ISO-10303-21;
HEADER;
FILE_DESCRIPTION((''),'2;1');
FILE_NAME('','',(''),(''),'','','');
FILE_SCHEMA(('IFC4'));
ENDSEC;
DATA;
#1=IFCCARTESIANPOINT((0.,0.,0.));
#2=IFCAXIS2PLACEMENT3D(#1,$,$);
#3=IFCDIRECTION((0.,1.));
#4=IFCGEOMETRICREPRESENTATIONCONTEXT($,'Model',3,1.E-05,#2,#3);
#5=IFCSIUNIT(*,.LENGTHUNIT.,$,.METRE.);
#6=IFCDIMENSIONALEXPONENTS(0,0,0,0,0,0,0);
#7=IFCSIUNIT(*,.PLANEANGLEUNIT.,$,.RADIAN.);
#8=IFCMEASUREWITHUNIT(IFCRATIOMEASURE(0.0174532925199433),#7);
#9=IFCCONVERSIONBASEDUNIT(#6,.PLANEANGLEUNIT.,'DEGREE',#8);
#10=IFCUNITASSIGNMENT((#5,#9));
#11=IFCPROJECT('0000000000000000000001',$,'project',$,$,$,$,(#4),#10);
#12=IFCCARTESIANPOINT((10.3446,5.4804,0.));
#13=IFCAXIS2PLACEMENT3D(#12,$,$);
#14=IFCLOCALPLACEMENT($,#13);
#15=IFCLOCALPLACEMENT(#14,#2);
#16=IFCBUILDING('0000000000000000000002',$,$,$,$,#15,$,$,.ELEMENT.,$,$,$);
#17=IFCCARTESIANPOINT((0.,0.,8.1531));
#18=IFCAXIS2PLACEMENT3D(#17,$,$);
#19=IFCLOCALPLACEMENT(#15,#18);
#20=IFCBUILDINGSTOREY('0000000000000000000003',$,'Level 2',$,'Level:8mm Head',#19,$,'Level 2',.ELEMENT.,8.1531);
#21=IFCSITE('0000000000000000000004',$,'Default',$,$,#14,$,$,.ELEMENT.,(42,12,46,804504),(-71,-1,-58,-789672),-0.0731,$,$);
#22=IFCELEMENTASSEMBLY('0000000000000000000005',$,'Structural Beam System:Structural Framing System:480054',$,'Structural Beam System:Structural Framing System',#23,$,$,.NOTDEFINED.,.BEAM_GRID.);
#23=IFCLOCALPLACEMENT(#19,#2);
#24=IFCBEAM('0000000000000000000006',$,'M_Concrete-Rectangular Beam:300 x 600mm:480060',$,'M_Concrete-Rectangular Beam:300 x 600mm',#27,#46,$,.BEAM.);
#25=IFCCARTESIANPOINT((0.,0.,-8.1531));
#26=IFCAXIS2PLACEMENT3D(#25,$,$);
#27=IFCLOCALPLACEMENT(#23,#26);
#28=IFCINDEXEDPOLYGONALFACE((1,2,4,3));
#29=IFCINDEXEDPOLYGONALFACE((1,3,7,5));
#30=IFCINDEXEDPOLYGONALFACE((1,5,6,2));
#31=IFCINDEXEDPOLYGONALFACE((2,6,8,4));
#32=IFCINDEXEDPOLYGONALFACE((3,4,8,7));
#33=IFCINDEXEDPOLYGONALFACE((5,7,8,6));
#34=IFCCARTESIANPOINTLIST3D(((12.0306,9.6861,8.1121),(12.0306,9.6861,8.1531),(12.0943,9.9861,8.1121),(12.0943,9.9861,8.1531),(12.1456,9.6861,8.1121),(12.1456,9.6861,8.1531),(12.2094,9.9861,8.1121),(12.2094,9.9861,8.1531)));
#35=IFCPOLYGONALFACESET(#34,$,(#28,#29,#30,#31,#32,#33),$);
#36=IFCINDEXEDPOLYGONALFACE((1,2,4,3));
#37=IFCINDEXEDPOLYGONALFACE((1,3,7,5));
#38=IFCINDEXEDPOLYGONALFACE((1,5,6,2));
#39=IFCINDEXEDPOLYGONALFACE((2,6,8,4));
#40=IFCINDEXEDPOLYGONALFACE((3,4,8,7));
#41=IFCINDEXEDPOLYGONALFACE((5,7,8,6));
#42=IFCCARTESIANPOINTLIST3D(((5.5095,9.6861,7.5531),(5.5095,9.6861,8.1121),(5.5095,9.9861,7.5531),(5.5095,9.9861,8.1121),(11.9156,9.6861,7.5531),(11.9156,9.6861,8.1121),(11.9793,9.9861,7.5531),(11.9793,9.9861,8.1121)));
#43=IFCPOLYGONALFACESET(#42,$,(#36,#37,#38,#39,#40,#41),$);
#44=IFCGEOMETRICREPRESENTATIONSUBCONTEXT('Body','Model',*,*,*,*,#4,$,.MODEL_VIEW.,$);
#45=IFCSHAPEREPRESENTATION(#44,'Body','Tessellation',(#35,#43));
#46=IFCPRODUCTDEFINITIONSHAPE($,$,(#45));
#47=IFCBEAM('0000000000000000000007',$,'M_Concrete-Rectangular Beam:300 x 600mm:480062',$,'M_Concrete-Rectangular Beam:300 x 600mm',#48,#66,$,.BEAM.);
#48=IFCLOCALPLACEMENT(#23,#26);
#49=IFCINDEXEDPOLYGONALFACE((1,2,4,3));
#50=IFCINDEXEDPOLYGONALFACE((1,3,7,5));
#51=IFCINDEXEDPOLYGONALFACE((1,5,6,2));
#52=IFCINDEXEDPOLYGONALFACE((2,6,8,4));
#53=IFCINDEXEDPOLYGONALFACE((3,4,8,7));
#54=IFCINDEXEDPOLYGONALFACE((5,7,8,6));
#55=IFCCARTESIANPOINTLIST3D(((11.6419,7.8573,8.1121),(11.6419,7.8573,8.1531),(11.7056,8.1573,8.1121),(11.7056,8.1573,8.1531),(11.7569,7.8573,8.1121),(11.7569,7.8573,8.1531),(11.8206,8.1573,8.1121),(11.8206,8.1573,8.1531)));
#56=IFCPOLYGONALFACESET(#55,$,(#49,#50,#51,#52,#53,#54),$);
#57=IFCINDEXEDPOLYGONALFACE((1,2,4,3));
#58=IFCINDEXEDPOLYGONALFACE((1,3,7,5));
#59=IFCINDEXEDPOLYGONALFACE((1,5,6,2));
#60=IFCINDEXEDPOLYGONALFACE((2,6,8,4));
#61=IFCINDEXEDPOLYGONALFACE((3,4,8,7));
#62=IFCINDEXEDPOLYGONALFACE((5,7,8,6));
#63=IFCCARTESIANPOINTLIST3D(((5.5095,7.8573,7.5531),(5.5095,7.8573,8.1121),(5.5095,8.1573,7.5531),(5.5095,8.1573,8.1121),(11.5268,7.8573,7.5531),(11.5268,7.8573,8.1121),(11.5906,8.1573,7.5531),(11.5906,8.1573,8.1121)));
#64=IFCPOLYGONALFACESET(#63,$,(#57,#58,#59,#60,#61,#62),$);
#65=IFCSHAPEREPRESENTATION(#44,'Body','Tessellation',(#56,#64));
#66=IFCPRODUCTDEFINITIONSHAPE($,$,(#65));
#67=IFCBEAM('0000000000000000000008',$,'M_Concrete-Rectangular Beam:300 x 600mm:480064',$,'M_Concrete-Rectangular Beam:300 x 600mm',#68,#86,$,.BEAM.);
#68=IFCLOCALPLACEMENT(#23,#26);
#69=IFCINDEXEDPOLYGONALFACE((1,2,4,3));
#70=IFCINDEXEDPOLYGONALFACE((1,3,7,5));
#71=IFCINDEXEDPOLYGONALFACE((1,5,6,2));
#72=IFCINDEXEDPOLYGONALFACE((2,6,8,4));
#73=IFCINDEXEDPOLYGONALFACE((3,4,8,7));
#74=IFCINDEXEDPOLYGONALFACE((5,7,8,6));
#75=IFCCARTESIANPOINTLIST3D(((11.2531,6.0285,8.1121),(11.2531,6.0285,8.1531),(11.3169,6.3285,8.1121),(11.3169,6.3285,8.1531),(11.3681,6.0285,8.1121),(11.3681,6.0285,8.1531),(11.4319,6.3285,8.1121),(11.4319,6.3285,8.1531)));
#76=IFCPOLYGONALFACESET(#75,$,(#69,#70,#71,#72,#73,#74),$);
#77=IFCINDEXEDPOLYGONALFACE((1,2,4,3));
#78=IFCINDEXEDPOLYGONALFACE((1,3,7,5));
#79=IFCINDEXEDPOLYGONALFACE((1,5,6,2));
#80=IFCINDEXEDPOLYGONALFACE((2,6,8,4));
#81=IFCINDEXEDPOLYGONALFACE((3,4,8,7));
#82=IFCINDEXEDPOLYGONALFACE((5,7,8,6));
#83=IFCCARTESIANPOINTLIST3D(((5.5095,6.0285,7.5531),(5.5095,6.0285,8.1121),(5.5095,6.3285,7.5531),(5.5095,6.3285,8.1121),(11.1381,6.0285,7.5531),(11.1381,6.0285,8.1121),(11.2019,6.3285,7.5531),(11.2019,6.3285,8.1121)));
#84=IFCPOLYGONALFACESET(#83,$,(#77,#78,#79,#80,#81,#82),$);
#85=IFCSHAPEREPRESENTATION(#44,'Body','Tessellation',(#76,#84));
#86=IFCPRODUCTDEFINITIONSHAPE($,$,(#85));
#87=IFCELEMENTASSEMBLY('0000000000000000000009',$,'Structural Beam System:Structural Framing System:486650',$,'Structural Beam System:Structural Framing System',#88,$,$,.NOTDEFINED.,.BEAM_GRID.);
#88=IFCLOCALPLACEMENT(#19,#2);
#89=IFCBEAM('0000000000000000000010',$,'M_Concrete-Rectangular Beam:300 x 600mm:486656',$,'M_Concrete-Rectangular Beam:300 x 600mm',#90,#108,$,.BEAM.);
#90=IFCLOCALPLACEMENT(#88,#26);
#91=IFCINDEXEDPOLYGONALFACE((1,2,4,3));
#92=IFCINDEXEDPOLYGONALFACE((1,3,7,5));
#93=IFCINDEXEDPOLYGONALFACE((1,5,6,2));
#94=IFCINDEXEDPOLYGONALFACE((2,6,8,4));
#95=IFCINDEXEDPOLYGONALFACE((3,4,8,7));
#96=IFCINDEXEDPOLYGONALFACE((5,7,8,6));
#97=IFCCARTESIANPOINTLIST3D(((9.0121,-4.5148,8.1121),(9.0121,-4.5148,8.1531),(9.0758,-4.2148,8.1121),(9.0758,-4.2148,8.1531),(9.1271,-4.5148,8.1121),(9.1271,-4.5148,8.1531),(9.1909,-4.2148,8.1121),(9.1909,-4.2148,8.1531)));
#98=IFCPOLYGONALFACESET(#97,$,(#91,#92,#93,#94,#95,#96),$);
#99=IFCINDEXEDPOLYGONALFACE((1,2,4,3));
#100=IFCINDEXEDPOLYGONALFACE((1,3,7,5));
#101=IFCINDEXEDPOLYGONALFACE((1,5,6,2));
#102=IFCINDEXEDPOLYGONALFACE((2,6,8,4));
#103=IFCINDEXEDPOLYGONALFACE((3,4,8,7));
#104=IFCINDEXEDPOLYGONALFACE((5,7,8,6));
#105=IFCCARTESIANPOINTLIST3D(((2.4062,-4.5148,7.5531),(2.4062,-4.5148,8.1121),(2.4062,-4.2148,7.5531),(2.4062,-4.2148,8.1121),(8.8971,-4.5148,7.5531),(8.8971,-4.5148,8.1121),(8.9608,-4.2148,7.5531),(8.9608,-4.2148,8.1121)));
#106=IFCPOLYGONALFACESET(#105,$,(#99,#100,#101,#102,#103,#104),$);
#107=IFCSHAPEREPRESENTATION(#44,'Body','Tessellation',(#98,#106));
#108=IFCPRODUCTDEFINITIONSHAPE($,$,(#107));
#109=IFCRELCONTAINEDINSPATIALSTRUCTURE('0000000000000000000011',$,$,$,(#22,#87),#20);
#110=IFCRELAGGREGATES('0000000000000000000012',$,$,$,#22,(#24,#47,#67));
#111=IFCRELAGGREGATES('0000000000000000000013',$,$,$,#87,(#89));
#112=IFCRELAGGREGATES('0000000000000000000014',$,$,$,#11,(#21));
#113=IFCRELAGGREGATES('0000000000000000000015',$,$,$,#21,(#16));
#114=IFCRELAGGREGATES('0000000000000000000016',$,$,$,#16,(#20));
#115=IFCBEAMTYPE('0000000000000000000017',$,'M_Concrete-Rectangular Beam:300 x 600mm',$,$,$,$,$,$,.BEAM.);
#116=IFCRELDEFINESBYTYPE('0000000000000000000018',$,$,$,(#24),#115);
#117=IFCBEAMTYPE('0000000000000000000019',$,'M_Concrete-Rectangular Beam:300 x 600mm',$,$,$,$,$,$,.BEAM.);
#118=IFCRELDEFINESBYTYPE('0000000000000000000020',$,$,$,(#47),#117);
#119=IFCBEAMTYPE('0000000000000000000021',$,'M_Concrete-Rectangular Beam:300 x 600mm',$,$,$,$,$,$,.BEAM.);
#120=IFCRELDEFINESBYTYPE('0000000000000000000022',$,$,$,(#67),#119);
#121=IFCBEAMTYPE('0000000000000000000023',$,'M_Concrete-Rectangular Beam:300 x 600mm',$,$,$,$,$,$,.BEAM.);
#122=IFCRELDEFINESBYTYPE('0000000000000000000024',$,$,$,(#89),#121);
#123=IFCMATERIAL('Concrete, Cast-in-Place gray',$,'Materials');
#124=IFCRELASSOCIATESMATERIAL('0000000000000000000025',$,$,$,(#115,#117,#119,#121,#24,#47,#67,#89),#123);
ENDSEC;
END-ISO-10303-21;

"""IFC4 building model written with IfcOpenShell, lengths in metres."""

from ifc_helpers import new_model, entity, si_unit, converted_unit, direction, frame, frame_2d, origin, place, context, subcontext, project, spatial, rectangle, extrude, clip, halfspace, source, transform, mapped, material, material_profile, profile_set, profile_usage, type_object, type_shapes, element, aggregate, save


model = new_model("IFC4")

# Units and contexts
model_context = context("Model", 3, precision=1e-05, world=origin(), true_north=direction((0.0, 1.0)))
body_context = subcontext(model_context, "Body", "Model", "MODEL_VIEW")
ifc_project = project(units=[si_unit("LENGTHUNIT", "METRE"), converted_unit("PLANEANGLEUNIT", "DEGREE", entity("IfcRatioMeasure", 0.0174532925199433), si_unit("PLANEANGLEUNIT", "RADIAN"), dimensions=[0, 0, 0, 0, 0, 0, 0])], contexts=[model_context])

# Site, building, storey
site_placement = place(None, frame((10.3446, 5.4804, 0.0)))
site = spatial("IfcSite", under=ifc_project, at=site_placement, Name="Default", CompositionType="ELEMENT", RefLatitude=(42, 12, 46, 804504), RefLongitude=(-71, -1, -58, -789672), RefElevation=-0.0731)
building_placement = place(site_placement, origin())
building = spatial("IfcBuilding", under=site, at=building_placement, CompositionType="ELEMENT")
storey_placement = place(building_placement, frame((0.0, 0.0, 8.1531)))
storey = spatial("IfcBuildingStorey", under=building, at=storey_placement, Name="Level 2", ObjectType="Level:8mm Head", LongName="Level 2", CompositionType="ELEMENT", Elevation=8.1531)

# Element assembly, beams
ifc_material_1 = material(Name="Concrete, Cast-in-Place gray", Category="Materials")
ifc_material_profile = material_profile(ifc_material_1, rectangle(XDim=0.559, YDim=0.3, at=frame_2d((0.0, 0.0), x_axis=(1.0, 0.0))), Name="300 x 600mm")
ifc_profile_set = profile_set([ifc_material_profile], Name="300 x 600mm")
assembly_1_placement = place(storey_placement, origin())
assembly_1 = element("IfcElementAssembly", 1, at=assembly_1_placement, inside=storey, Name="Structural Beam System:Structural Framing System:480054", ObjectType="Structural Beam System:Structural Framing System", AssemblyPlace="NOTDEFINED", PredefinedType="BEAM_GRID")
ifc_profile_usage_1 = profile_usage(ifc_profile_set, cardinal=8)
beam_type_1 = type_object("IfcBeamType", Name="M_Concrete-Rectangular Beam:300 x 600mm", PredefinedType="BEAM", material=ifc_profile_set)
shared_shape_1 = source(origin(), body_context, "Body", "Clipping", [
    clip(clip(extrude(rectangle(XDim=0.041, YDim=0.3, at=frame_2d((0.0, 0.0), x_axis=(1.0, 0.0))), frame((12.0306, 9.8361, 8.1326), z_axis=(1.0, 0.0, 0.0), x_axis=(0.0, 0.0, -1.0)), (0.0, 0.0, 1.0), 0.1788), halfspace(frame((12.1762, 10.3713, 8.1121), z_axis=(-0.978148, 0.207912, 0.0), x_axis=(0.0, 0.0, 1.0)), False)), halfspace(frame((12.1339, 9.6313, 8.5239), z_axis=(0.978148, -0.207912, 0.0), x_axis=(0.207912, 0.978148, 0.0)), False)),
    clip(extrude(rectangle(XDim=0.559, YDim=0.3, at=frame_2d((0.0, 0.0), x_axis=(1.0, 0.0))), frame((5.5095, 9.8361, 7.8326), z_axis=(1.0, 0.0, 0.0), x_axis=(0.0, 0.0, -1.0)), (0.0, 0.0, 1.0), 6.4698), halfspace(frame((8.6968, -5.457, 4.5531), z_axis=(0.978148, -0.207912, 0.0), x_axis=(-0.207912, -0.978148, 0.0)), False)),
])
type_shapes(beam_type_1, [shared_shape_1])
beam_1_placement = place(assembly_1_placement, frame((0.0, 0.0, -8.1531)))
beam_1 = element("IfcBeam", 2, at=beam_1_placement, type_object=beam_type_1, material=ifc_profile_usage_1, Name="M_Concrete-Rectangular Beam:300 x 600mm:480060", ObjectType="M_Concrete-Rectangular Beam:300 x 600mm", PredefinedType="BEAM", context=body_context, shape_type="MappedRepresentation", body=[
    mapped(shared_shape_1, transform((0.0, 0.0, 0.0), scale=1.0)),
])
ifc_profile_usage_2 = profile_usage(ifc_profile_set, cardinal=8)
beam_type_2 = type_object("IfcBeamType", Name="M_Concrete-Rectangular Beam:300 x 600mm", PredefinedType="BEAM", material=ifc_profile_set)
shared_shape_2 = source(origin(), body_context, "Body", "Clipping", [
    clip(clip(extrude(rectangle(XDim=0.041, YDim=0.3, at=frame_2d((0.0, 0.0), x_axis=(1.0, 0.0))), frame((11.6419, 8.0073, 8.1326), z_axis=(1.0, 0.0, 0.0), x_axis=(0.0, 0.0, -1.0)), (0.0, 0.0, 1.0), 0.1788), halfspace(frame((12.1762, 10.3713, 8.1121), z_axis=(-0.978148, 0.207912, 0.0), x_axis=(0.0, 0.0, 1.0)), False)), halfspace(frame((11.7452, 7.8025, 8.5239), z_axis=(0.978148, -0.207912, 0.0), x_axis=(0.207912, 0.978148, 0.0)), False)),
    clip(extrude(rectangle(XDim=0.559, YDim=0.3, at=frame_2d((0.0, 0.0), x_axis=(1.0, 0.0))), frame((5.5095, 8.0073, 7.8326), z_axis=(1.0, 0.0, 0.0), x_axis=(0.0, 0.0, -1.0)), (0.0, 0.0, 1.0), 6.0811), halfspace(frame((8.6968, -5.457, 4.5531), z_axis=(0.978148, -0.207912, 0.0), x_axis=(-0.207912, -0.978148, 0.0)), False)),
])
type_shapes(beam_type_2, [shared_shape_2])
beam_2_placement = place(assembly_1_placement, frame((0.0, 0.0, -8.1531)))
beam_2 = element("IfcBeam", 3, at=beam_2_placement, type_object=beam_type_2, material=ifc_profile_usage_2, Name="M_Concrete-Rectangular Beam:300 x 600mm:480062", ObjectType="M_Concrete-Rectangular Beam:300 x 600mm", PredefinedType="BEAM", context=body_context, shape_type="MappedRepresentation", body=[
    mapped(shared_shape_2, transform((0.0, 0.0, 0.0), scale=1.0)),
])
ifc_profile_usage_3 = profile_usage(ifc_profile_set, cardinal=8)
beam_type_3 = type_object("IfcBeamType", Name="M_Concrete-Rectangular Beam:300 x 600mm", PredefinedType="BEAM", material=ifc_profile_set)
shared_shape_3 = source(origin(), body_context, "Body", "Clipping", [
    clip(clip(extrude(rectangle(XDim=0.041, YDim=0.3, at=frame_2d((0.0, 0.0), x_axis=(1.0, 0.0))), frame((11.2531, 6.1785, 8.1326), z_axis=(1.0, 0.0, 0.0), x_axis=(0.0, 0.0, -1.0)), (0.0, 0.0, 1.0), 0.1788), halfspace(frame((12.1762, 10.3713, 8.1121), z_axis=(-0.978148, 0.207912, 0.0), x_axis=(0.0, 0.0, 1.0)), False)), halfspace(frame((11.3565, 5.9737, 8.5239), z_axis=(0.978148, -0.207912, 0.0), x_axis=(0.207912, 0.978148, 0.0)), False)),
    clip(extrude(rectangle(XDim=0.559, YDim=0.3, at=frame_2d((0.0, 0.0), x_axis=(1.0, 0.0))), frame((5.5095, 6.1785, 7.8326), z_axis=(1.0, 0.0, 0.0), x_axis=(0.0, 0.0, -1.0)), (0.0, 0.0, 1.0), 5.6923), halfspace(frame((8.6968, -5.457, 4.5531), z_axis=(0.978148, -0.207912, 0.0), x_axis=(-0.207912, -0.978148, 0.0)), False)),
])
type_shapes(beam_type_3, [shared_shape_3])
beam_3_placement = place(assembly_1_placement, frame((0.0, 0.0, -8.1531)))
beam_3 = element("IfcBeam", 4, at=beam_3_placement, type_object=beam_type_3, material=ifc_profile_usage_3, Name="M_Concrete-Rectangular Beam:300 x 600mm:480064", ObjectType="M_Concrete-Rectangular Beam:300 x 600mm", PredefinedType="BEAM", context=body_context, shape_type="MappedRepresentation", body=[
    mapped(shared_shape_3, transform((0.0, 0.0, 0.0), scale=1.0)),
])
aggregate(assembly_1, [beam_1, beam_2, beam_3])

# Element assembly, beam
assembly_2_placement = place(storey_placement, origin())
assembly_2 = element("IfcElementAssembly", 5, at=assembly_2_placement, inside=storey, Name="Structural Beam System:Structural Framing System:486650", ObjectType="Structural Beam System:Structural Framing System", AssemblyPlace="NOTDEFINED", PredefinedType="BEAM_GRID")
ifc_profile_usage_4 = profile_usage(ifc_profile_set, cardinal=8)
beam_type_4 = type_object("IfcBeamType", Name="M_Concrete-Rectangular Beam:300 x 600mm", PredefinedType="BEAM", material=ifc_profile_set)
shared_shape_4 = source(origin(), body_context, "Body", "Clipping", [
    clip(clip(extrude(rectangle(XDim=0.041, YDim=0.3, at=frame_2d((0.0, 0.0), x_axis=(1.0, 0.0))), frame((9.0121, -4.3648, 8.1326), z_axis=(1.0, 0.0, 0.0), x_axis=(0.0, 0.0, -1.0)), (0.0, 0.0, 1.0), 0.1788), halfspace(frame((10.4473, 2.2371, 8.1121), z_axis=(-0.978148, 0.207912, 0.0), x_axis=(0.0, 0.0, 1.0)), False)), halfspace(frame((9.1154, -4.5697, 8.5239), z_axis=(0.978148, -0.207912, 0.0), x_axis=(0.207912, 0.978148, 0.0)), False)),
    clip(extrude(rectangle(XDim=0.559, YDim=0.3, at=frame_2d((0.0, 0.0), x_axis=(1.0, 0.0))), frame((2.4062, -4.3648, 7.8326), z_axis=(1.0, 0.0, 0.0), x_axis=(0.0, 0.0, -1.0)), (0.0, 0.0, 1.0), 6.5547), halfspace(frame((8.6968, -5.457, 4.5531), z_axis=(0.978148, -0.207912, 0.0), x_axis=(-0.207912, -0.978148, 0.0)), False)),
])
type_shapes(beam_type_4, [shared_shape_4])
beam_4_placement = place(assembly_2_placement, frame((0.0, 0.0, -8.1531)))
beam_4 = element("IfcBeam", 6, at=beam_4_placement, type_object=beam_type_4, material=ifc_profile_usage_4, Name="M_Concrete-Rectangular Beam:300 x 600mm:486656", ObjectType="M_Concrete-Rectangular Beam:300 x 600mm", PredefinedType="BEAM", context=body_context, shape_type="MappedRepresentation", body=[
    mapped(shared_shape_4, transform((0.0, 0.0, 0.0), scale=1.0)),
])
aggregate(assembly_2, [beam_4])

save(model, "model.ifc")
